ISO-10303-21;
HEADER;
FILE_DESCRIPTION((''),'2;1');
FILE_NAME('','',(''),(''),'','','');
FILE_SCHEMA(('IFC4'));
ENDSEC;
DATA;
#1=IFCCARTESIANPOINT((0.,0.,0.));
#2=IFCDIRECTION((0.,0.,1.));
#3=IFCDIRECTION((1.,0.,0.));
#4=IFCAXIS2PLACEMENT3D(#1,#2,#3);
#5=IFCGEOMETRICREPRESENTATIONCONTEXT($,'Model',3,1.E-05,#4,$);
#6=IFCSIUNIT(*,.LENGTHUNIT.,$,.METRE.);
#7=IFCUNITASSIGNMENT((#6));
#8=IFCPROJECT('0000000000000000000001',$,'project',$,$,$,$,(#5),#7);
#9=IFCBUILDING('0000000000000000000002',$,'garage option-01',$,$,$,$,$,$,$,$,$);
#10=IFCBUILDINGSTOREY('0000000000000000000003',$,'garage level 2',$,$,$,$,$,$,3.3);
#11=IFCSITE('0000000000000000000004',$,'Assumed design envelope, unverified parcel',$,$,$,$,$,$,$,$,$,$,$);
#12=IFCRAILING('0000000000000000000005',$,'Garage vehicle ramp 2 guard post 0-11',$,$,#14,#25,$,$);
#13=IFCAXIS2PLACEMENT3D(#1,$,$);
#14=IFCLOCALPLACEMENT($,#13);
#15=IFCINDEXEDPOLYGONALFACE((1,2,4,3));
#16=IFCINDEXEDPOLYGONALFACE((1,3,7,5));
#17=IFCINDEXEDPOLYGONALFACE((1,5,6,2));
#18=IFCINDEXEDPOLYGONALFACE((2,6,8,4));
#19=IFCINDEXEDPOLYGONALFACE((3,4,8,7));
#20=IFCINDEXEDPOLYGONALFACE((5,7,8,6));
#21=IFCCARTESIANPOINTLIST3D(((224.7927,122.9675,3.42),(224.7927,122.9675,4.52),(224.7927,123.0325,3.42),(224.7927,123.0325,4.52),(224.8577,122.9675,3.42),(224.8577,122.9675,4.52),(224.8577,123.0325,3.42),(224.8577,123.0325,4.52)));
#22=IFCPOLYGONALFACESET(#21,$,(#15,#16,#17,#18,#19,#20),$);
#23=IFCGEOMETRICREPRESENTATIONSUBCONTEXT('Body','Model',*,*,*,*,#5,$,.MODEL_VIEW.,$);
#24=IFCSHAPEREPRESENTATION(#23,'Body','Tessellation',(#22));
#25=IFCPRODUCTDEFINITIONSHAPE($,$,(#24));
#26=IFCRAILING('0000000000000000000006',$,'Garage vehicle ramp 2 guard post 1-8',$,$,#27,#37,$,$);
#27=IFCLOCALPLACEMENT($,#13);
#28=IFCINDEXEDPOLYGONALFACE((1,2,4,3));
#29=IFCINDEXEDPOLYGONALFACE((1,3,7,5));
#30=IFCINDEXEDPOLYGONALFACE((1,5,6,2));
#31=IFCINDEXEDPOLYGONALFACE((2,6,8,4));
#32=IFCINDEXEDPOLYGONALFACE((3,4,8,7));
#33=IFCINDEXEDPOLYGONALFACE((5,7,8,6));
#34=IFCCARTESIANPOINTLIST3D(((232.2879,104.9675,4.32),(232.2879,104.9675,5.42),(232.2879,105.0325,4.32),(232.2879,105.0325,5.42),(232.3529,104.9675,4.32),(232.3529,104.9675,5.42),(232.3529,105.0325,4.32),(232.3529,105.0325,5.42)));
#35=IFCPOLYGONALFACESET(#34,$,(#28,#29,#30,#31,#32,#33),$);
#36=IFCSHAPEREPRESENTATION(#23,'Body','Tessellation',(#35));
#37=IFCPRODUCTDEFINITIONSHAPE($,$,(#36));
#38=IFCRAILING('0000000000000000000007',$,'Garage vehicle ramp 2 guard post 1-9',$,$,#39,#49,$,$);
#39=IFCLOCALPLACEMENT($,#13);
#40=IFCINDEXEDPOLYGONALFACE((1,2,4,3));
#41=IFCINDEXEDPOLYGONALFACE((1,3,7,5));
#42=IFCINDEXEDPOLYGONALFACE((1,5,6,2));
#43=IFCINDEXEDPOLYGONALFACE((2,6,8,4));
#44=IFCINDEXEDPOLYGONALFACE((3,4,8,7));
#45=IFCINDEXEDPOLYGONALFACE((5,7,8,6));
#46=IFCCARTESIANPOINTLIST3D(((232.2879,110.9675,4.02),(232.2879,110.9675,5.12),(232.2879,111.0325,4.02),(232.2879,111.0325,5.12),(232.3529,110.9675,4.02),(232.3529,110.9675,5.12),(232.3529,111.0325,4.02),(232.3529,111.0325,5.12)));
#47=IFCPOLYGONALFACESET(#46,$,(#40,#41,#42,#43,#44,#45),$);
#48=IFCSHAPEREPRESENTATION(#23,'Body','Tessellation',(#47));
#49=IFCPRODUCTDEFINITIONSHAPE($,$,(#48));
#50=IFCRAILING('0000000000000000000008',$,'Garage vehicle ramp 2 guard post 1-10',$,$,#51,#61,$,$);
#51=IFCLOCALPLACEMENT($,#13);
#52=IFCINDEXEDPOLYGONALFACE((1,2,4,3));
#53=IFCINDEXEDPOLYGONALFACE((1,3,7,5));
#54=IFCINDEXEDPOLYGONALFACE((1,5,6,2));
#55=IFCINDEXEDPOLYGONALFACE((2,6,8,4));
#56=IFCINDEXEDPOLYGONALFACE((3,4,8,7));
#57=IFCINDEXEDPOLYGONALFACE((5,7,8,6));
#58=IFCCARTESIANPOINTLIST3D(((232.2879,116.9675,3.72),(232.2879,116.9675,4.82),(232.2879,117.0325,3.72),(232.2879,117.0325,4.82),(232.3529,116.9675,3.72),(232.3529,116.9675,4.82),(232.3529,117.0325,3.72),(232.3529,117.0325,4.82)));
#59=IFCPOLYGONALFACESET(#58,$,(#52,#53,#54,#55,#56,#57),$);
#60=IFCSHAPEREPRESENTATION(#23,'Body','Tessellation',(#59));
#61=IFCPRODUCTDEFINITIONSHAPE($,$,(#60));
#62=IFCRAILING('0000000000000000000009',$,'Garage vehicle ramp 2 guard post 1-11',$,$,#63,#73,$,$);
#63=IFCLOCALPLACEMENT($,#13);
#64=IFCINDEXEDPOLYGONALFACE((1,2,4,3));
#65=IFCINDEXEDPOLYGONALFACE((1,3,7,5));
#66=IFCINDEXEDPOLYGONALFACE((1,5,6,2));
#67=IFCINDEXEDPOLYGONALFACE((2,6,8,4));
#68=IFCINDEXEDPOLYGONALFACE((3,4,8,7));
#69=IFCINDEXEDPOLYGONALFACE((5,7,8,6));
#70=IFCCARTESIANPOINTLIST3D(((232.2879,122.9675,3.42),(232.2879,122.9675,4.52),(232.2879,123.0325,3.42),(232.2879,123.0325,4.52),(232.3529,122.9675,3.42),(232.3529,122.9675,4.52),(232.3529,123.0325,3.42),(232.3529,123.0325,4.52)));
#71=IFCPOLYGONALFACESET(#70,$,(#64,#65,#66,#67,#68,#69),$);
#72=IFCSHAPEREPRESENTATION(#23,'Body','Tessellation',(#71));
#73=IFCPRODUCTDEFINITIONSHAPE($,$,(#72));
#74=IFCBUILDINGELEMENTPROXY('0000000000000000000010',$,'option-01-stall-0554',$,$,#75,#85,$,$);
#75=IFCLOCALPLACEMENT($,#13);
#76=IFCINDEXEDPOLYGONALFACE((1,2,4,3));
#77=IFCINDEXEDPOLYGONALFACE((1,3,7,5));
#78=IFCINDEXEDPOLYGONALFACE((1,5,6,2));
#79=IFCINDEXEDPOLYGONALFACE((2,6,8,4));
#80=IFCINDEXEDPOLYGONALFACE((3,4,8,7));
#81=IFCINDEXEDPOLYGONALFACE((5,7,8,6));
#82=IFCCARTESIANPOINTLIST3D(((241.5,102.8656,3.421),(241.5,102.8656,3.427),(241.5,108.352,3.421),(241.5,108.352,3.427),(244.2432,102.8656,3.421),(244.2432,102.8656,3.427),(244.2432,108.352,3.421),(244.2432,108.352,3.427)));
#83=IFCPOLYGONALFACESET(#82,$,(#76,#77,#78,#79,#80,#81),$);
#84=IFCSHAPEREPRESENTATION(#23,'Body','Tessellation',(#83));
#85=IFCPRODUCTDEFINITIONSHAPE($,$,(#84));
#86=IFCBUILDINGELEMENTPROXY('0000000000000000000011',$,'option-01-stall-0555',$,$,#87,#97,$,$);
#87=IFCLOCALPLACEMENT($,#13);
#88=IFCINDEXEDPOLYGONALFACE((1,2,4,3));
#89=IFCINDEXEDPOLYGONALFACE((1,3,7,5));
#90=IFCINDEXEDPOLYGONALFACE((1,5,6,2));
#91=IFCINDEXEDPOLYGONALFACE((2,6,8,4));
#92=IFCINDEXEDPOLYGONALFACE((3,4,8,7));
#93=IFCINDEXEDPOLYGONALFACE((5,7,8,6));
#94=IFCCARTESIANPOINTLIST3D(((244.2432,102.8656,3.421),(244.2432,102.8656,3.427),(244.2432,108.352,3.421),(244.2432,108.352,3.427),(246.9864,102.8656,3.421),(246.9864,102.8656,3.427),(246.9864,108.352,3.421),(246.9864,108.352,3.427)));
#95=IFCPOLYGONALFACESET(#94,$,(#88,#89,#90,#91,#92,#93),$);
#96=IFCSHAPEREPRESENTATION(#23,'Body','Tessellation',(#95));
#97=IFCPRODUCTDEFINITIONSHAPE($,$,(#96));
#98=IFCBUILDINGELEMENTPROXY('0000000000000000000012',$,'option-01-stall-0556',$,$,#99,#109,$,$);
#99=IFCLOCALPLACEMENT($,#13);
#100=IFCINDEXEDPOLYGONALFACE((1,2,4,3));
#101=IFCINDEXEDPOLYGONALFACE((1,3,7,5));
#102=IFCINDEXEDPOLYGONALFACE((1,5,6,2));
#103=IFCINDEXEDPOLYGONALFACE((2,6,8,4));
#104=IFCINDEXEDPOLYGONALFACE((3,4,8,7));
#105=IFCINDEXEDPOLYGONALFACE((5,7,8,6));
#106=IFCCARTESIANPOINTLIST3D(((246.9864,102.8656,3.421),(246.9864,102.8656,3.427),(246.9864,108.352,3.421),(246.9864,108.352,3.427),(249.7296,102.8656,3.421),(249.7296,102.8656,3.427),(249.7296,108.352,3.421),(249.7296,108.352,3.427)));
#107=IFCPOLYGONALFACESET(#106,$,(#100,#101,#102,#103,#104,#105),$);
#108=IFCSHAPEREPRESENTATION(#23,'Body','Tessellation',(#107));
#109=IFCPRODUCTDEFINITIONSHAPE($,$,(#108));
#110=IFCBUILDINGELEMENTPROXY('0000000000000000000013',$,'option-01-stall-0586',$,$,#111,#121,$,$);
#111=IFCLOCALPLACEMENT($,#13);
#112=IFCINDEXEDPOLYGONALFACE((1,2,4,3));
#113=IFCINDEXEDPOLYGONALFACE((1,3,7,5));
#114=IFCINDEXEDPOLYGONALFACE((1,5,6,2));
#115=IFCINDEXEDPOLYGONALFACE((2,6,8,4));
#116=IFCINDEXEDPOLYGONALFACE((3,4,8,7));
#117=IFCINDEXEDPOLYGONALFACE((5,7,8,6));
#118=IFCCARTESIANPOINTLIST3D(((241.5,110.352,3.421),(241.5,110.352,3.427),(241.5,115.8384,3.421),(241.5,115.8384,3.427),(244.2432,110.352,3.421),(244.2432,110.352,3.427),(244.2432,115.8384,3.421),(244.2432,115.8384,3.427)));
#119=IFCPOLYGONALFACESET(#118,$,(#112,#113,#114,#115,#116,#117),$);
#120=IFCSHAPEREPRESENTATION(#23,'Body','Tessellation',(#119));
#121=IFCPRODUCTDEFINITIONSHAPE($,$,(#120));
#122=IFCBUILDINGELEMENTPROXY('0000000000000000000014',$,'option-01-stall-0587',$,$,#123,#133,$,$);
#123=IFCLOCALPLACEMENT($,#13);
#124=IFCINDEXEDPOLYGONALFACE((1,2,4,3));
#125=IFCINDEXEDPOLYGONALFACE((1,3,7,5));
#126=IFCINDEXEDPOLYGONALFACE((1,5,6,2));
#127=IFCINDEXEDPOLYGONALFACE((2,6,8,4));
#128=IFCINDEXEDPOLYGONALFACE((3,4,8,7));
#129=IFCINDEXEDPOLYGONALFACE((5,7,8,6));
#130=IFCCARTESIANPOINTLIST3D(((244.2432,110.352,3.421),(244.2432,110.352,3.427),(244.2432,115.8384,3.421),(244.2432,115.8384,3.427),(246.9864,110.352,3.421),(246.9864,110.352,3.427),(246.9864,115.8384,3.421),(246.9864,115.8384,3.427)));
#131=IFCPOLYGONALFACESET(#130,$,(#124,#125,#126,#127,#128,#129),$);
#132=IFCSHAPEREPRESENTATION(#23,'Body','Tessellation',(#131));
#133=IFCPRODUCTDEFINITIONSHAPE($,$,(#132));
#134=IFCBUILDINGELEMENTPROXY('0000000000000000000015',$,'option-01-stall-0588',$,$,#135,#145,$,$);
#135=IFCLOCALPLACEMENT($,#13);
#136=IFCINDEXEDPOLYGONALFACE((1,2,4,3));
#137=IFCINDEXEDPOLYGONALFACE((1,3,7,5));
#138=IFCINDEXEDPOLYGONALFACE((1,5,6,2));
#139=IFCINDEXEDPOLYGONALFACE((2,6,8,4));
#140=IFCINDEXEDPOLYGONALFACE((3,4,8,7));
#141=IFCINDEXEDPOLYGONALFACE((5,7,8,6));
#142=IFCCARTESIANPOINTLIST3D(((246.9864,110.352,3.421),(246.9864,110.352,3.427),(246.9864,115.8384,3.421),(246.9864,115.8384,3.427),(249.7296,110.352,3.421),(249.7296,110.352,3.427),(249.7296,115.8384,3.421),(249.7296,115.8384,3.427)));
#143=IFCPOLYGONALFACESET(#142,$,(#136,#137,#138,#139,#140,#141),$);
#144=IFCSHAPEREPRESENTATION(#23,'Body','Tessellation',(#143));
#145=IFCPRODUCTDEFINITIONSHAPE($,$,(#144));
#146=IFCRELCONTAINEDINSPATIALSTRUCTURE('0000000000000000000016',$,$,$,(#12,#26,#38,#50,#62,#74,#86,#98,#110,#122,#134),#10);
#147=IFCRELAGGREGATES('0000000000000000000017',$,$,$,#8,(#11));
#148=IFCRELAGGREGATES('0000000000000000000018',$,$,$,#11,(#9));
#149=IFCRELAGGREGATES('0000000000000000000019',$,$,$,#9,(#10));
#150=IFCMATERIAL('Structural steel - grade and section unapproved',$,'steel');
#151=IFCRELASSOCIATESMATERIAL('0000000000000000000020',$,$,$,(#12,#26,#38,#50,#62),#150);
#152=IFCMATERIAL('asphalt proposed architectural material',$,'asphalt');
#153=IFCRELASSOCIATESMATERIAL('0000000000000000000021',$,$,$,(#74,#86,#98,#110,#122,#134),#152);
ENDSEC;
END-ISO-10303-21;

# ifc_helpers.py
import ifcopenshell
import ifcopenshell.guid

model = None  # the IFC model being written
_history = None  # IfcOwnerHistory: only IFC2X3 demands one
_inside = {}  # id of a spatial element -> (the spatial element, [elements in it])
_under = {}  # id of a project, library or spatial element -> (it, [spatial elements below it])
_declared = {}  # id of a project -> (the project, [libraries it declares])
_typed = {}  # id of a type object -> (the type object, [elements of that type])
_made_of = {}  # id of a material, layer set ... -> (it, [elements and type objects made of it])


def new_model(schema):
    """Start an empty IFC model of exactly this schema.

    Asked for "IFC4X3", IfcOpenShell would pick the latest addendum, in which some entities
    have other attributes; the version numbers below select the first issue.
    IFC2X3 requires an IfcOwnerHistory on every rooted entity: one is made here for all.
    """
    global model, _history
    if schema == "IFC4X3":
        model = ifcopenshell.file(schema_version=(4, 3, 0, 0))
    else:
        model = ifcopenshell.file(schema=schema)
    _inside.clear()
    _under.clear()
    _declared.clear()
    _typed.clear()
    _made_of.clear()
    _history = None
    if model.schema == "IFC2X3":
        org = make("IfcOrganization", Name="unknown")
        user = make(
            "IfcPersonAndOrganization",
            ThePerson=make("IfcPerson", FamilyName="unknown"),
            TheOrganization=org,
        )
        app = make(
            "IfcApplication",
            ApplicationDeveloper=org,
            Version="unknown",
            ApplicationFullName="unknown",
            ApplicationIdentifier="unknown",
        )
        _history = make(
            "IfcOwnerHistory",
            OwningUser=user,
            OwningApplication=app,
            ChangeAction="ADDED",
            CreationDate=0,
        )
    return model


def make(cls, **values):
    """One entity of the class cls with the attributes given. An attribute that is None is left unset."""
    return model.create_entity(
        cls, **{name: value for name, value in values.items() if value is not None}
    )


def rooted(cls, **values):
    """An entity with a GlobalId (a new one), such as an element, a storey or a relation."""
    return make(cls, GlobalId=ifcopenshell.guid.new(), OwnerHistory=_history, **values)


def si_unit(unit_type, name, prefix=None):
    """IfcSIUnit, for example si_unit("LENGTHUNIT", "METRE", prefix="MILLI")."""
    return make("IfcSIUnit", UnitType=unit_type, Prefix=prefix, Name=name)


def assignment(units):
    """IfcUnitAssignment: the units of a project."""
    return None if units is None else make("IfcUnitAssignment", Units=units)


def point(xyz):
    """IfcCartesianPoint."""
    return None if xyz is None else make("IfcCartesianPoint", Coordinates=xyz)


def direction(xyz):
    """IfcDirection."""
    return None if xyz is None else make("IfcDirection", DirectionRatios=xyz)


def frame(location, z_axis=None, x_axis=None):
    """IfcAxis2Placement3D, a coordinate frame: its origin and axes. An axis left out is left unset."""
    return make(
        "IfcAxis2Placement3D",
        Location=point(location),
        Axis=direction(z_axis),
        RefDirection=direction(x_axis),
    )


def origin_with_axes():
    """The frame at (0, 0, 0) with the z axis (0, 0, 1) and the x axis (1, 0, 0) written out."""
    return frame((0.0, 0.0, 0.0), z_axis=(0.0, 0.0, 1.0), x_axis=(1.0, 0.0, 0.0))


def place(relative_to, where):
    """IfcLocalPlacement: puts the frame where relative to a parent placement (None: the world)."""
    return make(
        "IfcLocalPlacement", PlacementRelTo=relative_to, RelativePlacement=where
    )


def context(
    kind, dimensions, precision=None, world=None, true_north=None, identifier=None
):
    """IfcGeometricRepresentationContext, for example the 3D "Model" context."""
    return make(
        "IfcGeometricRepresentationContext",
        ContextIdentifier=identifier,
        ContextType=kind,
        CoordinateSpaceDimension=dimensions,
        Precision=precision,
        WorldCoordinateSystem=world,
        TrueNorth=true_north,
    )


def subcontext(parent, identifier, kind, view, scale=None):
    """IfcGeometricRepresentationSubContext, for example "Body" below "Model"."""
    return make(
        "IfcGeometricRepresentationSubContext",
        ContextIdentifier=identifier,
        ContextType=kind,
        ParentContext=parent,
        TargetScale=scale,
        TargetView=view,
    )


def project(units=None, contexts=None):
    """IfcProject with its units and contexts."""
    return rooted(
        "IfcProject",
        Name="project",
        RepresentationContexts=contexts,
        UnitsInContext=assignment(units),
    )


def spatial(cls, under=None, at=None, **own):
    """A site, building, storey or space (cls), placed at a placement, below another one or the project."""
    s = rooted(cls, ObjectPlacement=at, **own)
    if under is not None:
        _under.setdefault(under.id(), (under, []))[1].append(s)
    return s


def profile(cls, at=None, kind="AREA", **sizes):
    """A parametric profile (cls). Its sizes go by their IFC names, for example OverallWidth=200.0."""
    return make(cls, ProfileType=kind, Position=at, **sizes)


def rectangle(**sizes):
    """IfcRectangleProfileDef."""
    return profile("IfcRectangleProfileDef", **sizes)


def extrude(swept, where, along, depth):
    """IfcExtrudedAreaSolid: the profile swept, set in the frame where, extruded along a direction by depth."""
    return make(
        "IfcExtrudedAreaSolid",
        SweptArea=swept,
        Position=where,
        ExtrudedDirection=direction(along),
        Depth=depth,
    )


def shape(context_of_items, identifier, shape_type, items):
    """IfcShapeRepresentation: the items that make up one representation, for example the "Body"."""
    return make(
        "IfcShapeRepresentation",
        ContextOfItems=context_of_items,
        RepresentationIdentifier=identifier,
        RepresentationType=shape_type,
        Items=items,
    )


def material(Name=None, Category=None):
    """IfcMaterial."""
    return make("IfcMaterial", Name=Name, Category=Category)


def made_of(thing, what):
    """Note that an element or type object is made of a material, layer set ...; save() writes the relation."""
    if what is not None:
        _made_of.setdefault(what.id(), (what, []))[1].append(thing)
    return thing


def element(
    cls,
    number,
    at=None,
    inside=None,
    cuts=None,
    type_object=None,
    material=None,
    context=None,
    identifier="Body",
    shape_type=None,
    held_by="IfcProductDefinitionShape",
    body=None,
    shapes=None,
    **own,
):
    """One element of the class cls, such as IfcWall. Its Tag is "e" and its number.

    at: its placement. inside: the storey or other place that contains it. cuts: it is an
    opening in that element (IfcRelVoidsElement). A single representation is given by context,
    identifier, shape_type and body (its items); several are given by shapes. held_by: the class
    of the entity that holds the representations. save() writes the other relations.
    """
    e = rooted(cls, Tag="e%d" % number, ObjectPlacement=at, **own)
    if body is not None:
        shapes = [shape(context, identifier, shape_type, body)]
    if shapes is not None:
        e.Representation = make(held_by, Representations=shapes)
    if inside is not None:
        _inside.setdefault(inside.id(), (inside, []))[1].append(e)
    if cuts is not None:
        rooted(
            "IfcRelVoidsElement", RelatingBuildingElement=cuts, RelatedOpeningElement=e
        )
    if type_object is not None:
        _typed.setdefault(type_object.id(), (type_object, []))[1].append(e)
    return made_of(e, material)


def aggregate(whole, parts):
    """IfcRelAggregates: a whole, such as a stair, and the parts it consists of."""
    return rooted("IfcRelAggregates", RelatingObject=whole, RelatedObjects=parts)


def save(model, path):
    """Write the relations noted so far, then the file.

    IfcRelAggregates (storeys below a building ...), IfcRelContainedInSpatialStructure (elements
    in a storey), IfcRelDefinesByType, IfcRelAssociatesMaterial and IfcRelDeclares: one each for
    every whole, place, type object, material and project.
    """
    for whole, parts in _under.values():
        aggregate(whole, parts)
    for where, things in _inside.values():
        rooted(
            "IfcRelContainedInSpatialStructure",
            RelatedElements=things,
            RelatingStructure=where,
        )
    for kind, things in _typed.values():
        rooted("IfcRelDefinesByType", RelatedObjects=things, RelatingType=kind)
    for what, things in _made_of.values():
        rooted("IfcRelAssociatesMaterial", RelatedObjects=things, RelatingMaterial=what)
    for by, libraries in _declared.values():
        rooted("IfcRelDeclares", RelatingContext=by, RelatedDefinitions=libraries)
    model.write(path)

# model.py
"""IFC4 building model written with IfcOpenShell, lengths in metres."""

from ifc_helpers import new_model, si_unit, frame, origin_with_axes, place, context, subcontext, project, spatial, rectangle, extrude, material, element, save


model = new_model("IFC4")

# Units and contexts
model_context = context("Model", 3, precision=1e-05, world=origin_with_axes())
body_context = subcontext(model_context, "Body", "Model", "MODEL_VIEW")
ifc_project = project(units=[si_unit("LENGTHUNIT", "METRE")], contexts=[model_context])

# Site, building, storey
site = spatial("IfcSite", under=ifc_project, Name="Assumed design envelope, unverified parcel")
building = spatial("IfcBuilding", under=site, Name="garage option-01")
storey = spatial("IfcBuildingStorey", under=building, Name="garage level 2", Elevation=3.3)

# Shared definitions
ifc_material_1 = material(Name="Structural steel - grade and section unapproved", Category="steel")

# Railings
for number, where, z_axis, x_axis, name in (
    (1, (224.8252, 123.0, 3.42), (0.0, 0.0, 1.0), (-1.0, 0.0, 0.0), "Garage vehicle ramp 2 guard post 0-11"),
    (2, (232.3204, 105.0, 4.32), (0.0, 0.0, 1.0), (-1.0, 0.0, 0.0), "Garage vehicle ramp 2 guard post 1-8"),
    (3, (232.3204, 111.0, 4.02), (0.0, 0.0, 1.0), (-1.0, 0.0, 0.0), "Garage vehicle ramp 2 guard post 1-9"),
):
    element("IfcRailing", number, at=place(None, frame(where, z_axis=z_axis, x_axis=x_axis)), inside=storey, material=ifc_material_1, Name=name, context=body_context, shape_type="SweptSolid", body=[
        extrude(rectangle(XDim=0.065, YDim=0.065), origin_with_axes(), (0.0, 0.0, 1.0), 1.1),
    ])
railing_1_placement = place(None, frame((232.3204, 117.0, 3.72), z_axis=(0.0, 0.0, 1.0), x_axis=(-1.0, 0.0, 0.0)))
element("IfcRailing", 4, at=railing_1_placement, inside=storey, material=ifc_material_1, Name="Garage vehicle ramp 2 guard post 1-10", context=body_context, shape_type="SweptSolid", body=[
    extrude(rectangle(XDim=0.065, YDim=0.065), origin_with_axes(), (0.0, 0.0, 1.0), 1.1),
])
railing_2_placement = place(None, frame((232.3204, 123.0, 3.42), z_axis=(0.0, 0.0, 1.0), x_axis=(-1.0, 0.0, 0.0)))
element("IfcRailing", 5, at=railing_2_placement, inside=storey, material=ifc_material_1, Name="Garage vehicle ramp 2 guard post 1-11", context=body_context, shape_type="SweptSolid", body=[
    extrude(rectangle(XDim=0.065, YDim=0.065), origin_with_axes(), (0.0, 0.0, 1.0), 1.1),
])

# Building element proxies
ifc_material_2 = material(Name="asphalt proposed architectural material", Category="asphalt")
for number, where, z_axis, x_axis, name in (
    (6, (242.8716, 105.6088, 3.421), (0.0, 0.0, 1.0), (1.0, 0.0, 0.0), "option-01-stall-0554"),
    (7, (245.6148, 105.6088, 3.421), (0.0, 0.0, 1.0), (1.0, 0.0, 0.0), "option-01-stall-0555"),
    (8, (248.358, 105.6088, 3.421), (0.0, 0.0, 1.0), (1.0, 0.0, 0.0), "option-01-stall-0556"),
    (9, (242.8716, 113.0952, 3.421), (0.0, 0.0, 1.0), (1.0, 0.0, 0.0), "option-01-stall-0586"),
    (10, (245.6148, 113.0952, 3.421), (0.0, 0.0, 1.0), (1.0, 0.0, 0.0), "option-01-stall-0587"),
    (11, (248.358, 113.0952, 3.421), (0.0, 0.0, 1.0), (1.0, 0.0, 0.0), "option-01-stall-0588"),
):
    element("IfcBuildingElementProxy", number, at=place(None, frame(where, z_axis=z_axis, x_axis=x_axis)), inside=storey, material=ifc_material_2, Name=name, context=body_context, shape_type="SweptSolid", body=[
        extrude(rectangle(XDim=2.7432, YDim=5.4864), origin_with_axes(), (0.0, 0.0, 1.0), 0.006),
    ])

save(model, "model.ifc")
